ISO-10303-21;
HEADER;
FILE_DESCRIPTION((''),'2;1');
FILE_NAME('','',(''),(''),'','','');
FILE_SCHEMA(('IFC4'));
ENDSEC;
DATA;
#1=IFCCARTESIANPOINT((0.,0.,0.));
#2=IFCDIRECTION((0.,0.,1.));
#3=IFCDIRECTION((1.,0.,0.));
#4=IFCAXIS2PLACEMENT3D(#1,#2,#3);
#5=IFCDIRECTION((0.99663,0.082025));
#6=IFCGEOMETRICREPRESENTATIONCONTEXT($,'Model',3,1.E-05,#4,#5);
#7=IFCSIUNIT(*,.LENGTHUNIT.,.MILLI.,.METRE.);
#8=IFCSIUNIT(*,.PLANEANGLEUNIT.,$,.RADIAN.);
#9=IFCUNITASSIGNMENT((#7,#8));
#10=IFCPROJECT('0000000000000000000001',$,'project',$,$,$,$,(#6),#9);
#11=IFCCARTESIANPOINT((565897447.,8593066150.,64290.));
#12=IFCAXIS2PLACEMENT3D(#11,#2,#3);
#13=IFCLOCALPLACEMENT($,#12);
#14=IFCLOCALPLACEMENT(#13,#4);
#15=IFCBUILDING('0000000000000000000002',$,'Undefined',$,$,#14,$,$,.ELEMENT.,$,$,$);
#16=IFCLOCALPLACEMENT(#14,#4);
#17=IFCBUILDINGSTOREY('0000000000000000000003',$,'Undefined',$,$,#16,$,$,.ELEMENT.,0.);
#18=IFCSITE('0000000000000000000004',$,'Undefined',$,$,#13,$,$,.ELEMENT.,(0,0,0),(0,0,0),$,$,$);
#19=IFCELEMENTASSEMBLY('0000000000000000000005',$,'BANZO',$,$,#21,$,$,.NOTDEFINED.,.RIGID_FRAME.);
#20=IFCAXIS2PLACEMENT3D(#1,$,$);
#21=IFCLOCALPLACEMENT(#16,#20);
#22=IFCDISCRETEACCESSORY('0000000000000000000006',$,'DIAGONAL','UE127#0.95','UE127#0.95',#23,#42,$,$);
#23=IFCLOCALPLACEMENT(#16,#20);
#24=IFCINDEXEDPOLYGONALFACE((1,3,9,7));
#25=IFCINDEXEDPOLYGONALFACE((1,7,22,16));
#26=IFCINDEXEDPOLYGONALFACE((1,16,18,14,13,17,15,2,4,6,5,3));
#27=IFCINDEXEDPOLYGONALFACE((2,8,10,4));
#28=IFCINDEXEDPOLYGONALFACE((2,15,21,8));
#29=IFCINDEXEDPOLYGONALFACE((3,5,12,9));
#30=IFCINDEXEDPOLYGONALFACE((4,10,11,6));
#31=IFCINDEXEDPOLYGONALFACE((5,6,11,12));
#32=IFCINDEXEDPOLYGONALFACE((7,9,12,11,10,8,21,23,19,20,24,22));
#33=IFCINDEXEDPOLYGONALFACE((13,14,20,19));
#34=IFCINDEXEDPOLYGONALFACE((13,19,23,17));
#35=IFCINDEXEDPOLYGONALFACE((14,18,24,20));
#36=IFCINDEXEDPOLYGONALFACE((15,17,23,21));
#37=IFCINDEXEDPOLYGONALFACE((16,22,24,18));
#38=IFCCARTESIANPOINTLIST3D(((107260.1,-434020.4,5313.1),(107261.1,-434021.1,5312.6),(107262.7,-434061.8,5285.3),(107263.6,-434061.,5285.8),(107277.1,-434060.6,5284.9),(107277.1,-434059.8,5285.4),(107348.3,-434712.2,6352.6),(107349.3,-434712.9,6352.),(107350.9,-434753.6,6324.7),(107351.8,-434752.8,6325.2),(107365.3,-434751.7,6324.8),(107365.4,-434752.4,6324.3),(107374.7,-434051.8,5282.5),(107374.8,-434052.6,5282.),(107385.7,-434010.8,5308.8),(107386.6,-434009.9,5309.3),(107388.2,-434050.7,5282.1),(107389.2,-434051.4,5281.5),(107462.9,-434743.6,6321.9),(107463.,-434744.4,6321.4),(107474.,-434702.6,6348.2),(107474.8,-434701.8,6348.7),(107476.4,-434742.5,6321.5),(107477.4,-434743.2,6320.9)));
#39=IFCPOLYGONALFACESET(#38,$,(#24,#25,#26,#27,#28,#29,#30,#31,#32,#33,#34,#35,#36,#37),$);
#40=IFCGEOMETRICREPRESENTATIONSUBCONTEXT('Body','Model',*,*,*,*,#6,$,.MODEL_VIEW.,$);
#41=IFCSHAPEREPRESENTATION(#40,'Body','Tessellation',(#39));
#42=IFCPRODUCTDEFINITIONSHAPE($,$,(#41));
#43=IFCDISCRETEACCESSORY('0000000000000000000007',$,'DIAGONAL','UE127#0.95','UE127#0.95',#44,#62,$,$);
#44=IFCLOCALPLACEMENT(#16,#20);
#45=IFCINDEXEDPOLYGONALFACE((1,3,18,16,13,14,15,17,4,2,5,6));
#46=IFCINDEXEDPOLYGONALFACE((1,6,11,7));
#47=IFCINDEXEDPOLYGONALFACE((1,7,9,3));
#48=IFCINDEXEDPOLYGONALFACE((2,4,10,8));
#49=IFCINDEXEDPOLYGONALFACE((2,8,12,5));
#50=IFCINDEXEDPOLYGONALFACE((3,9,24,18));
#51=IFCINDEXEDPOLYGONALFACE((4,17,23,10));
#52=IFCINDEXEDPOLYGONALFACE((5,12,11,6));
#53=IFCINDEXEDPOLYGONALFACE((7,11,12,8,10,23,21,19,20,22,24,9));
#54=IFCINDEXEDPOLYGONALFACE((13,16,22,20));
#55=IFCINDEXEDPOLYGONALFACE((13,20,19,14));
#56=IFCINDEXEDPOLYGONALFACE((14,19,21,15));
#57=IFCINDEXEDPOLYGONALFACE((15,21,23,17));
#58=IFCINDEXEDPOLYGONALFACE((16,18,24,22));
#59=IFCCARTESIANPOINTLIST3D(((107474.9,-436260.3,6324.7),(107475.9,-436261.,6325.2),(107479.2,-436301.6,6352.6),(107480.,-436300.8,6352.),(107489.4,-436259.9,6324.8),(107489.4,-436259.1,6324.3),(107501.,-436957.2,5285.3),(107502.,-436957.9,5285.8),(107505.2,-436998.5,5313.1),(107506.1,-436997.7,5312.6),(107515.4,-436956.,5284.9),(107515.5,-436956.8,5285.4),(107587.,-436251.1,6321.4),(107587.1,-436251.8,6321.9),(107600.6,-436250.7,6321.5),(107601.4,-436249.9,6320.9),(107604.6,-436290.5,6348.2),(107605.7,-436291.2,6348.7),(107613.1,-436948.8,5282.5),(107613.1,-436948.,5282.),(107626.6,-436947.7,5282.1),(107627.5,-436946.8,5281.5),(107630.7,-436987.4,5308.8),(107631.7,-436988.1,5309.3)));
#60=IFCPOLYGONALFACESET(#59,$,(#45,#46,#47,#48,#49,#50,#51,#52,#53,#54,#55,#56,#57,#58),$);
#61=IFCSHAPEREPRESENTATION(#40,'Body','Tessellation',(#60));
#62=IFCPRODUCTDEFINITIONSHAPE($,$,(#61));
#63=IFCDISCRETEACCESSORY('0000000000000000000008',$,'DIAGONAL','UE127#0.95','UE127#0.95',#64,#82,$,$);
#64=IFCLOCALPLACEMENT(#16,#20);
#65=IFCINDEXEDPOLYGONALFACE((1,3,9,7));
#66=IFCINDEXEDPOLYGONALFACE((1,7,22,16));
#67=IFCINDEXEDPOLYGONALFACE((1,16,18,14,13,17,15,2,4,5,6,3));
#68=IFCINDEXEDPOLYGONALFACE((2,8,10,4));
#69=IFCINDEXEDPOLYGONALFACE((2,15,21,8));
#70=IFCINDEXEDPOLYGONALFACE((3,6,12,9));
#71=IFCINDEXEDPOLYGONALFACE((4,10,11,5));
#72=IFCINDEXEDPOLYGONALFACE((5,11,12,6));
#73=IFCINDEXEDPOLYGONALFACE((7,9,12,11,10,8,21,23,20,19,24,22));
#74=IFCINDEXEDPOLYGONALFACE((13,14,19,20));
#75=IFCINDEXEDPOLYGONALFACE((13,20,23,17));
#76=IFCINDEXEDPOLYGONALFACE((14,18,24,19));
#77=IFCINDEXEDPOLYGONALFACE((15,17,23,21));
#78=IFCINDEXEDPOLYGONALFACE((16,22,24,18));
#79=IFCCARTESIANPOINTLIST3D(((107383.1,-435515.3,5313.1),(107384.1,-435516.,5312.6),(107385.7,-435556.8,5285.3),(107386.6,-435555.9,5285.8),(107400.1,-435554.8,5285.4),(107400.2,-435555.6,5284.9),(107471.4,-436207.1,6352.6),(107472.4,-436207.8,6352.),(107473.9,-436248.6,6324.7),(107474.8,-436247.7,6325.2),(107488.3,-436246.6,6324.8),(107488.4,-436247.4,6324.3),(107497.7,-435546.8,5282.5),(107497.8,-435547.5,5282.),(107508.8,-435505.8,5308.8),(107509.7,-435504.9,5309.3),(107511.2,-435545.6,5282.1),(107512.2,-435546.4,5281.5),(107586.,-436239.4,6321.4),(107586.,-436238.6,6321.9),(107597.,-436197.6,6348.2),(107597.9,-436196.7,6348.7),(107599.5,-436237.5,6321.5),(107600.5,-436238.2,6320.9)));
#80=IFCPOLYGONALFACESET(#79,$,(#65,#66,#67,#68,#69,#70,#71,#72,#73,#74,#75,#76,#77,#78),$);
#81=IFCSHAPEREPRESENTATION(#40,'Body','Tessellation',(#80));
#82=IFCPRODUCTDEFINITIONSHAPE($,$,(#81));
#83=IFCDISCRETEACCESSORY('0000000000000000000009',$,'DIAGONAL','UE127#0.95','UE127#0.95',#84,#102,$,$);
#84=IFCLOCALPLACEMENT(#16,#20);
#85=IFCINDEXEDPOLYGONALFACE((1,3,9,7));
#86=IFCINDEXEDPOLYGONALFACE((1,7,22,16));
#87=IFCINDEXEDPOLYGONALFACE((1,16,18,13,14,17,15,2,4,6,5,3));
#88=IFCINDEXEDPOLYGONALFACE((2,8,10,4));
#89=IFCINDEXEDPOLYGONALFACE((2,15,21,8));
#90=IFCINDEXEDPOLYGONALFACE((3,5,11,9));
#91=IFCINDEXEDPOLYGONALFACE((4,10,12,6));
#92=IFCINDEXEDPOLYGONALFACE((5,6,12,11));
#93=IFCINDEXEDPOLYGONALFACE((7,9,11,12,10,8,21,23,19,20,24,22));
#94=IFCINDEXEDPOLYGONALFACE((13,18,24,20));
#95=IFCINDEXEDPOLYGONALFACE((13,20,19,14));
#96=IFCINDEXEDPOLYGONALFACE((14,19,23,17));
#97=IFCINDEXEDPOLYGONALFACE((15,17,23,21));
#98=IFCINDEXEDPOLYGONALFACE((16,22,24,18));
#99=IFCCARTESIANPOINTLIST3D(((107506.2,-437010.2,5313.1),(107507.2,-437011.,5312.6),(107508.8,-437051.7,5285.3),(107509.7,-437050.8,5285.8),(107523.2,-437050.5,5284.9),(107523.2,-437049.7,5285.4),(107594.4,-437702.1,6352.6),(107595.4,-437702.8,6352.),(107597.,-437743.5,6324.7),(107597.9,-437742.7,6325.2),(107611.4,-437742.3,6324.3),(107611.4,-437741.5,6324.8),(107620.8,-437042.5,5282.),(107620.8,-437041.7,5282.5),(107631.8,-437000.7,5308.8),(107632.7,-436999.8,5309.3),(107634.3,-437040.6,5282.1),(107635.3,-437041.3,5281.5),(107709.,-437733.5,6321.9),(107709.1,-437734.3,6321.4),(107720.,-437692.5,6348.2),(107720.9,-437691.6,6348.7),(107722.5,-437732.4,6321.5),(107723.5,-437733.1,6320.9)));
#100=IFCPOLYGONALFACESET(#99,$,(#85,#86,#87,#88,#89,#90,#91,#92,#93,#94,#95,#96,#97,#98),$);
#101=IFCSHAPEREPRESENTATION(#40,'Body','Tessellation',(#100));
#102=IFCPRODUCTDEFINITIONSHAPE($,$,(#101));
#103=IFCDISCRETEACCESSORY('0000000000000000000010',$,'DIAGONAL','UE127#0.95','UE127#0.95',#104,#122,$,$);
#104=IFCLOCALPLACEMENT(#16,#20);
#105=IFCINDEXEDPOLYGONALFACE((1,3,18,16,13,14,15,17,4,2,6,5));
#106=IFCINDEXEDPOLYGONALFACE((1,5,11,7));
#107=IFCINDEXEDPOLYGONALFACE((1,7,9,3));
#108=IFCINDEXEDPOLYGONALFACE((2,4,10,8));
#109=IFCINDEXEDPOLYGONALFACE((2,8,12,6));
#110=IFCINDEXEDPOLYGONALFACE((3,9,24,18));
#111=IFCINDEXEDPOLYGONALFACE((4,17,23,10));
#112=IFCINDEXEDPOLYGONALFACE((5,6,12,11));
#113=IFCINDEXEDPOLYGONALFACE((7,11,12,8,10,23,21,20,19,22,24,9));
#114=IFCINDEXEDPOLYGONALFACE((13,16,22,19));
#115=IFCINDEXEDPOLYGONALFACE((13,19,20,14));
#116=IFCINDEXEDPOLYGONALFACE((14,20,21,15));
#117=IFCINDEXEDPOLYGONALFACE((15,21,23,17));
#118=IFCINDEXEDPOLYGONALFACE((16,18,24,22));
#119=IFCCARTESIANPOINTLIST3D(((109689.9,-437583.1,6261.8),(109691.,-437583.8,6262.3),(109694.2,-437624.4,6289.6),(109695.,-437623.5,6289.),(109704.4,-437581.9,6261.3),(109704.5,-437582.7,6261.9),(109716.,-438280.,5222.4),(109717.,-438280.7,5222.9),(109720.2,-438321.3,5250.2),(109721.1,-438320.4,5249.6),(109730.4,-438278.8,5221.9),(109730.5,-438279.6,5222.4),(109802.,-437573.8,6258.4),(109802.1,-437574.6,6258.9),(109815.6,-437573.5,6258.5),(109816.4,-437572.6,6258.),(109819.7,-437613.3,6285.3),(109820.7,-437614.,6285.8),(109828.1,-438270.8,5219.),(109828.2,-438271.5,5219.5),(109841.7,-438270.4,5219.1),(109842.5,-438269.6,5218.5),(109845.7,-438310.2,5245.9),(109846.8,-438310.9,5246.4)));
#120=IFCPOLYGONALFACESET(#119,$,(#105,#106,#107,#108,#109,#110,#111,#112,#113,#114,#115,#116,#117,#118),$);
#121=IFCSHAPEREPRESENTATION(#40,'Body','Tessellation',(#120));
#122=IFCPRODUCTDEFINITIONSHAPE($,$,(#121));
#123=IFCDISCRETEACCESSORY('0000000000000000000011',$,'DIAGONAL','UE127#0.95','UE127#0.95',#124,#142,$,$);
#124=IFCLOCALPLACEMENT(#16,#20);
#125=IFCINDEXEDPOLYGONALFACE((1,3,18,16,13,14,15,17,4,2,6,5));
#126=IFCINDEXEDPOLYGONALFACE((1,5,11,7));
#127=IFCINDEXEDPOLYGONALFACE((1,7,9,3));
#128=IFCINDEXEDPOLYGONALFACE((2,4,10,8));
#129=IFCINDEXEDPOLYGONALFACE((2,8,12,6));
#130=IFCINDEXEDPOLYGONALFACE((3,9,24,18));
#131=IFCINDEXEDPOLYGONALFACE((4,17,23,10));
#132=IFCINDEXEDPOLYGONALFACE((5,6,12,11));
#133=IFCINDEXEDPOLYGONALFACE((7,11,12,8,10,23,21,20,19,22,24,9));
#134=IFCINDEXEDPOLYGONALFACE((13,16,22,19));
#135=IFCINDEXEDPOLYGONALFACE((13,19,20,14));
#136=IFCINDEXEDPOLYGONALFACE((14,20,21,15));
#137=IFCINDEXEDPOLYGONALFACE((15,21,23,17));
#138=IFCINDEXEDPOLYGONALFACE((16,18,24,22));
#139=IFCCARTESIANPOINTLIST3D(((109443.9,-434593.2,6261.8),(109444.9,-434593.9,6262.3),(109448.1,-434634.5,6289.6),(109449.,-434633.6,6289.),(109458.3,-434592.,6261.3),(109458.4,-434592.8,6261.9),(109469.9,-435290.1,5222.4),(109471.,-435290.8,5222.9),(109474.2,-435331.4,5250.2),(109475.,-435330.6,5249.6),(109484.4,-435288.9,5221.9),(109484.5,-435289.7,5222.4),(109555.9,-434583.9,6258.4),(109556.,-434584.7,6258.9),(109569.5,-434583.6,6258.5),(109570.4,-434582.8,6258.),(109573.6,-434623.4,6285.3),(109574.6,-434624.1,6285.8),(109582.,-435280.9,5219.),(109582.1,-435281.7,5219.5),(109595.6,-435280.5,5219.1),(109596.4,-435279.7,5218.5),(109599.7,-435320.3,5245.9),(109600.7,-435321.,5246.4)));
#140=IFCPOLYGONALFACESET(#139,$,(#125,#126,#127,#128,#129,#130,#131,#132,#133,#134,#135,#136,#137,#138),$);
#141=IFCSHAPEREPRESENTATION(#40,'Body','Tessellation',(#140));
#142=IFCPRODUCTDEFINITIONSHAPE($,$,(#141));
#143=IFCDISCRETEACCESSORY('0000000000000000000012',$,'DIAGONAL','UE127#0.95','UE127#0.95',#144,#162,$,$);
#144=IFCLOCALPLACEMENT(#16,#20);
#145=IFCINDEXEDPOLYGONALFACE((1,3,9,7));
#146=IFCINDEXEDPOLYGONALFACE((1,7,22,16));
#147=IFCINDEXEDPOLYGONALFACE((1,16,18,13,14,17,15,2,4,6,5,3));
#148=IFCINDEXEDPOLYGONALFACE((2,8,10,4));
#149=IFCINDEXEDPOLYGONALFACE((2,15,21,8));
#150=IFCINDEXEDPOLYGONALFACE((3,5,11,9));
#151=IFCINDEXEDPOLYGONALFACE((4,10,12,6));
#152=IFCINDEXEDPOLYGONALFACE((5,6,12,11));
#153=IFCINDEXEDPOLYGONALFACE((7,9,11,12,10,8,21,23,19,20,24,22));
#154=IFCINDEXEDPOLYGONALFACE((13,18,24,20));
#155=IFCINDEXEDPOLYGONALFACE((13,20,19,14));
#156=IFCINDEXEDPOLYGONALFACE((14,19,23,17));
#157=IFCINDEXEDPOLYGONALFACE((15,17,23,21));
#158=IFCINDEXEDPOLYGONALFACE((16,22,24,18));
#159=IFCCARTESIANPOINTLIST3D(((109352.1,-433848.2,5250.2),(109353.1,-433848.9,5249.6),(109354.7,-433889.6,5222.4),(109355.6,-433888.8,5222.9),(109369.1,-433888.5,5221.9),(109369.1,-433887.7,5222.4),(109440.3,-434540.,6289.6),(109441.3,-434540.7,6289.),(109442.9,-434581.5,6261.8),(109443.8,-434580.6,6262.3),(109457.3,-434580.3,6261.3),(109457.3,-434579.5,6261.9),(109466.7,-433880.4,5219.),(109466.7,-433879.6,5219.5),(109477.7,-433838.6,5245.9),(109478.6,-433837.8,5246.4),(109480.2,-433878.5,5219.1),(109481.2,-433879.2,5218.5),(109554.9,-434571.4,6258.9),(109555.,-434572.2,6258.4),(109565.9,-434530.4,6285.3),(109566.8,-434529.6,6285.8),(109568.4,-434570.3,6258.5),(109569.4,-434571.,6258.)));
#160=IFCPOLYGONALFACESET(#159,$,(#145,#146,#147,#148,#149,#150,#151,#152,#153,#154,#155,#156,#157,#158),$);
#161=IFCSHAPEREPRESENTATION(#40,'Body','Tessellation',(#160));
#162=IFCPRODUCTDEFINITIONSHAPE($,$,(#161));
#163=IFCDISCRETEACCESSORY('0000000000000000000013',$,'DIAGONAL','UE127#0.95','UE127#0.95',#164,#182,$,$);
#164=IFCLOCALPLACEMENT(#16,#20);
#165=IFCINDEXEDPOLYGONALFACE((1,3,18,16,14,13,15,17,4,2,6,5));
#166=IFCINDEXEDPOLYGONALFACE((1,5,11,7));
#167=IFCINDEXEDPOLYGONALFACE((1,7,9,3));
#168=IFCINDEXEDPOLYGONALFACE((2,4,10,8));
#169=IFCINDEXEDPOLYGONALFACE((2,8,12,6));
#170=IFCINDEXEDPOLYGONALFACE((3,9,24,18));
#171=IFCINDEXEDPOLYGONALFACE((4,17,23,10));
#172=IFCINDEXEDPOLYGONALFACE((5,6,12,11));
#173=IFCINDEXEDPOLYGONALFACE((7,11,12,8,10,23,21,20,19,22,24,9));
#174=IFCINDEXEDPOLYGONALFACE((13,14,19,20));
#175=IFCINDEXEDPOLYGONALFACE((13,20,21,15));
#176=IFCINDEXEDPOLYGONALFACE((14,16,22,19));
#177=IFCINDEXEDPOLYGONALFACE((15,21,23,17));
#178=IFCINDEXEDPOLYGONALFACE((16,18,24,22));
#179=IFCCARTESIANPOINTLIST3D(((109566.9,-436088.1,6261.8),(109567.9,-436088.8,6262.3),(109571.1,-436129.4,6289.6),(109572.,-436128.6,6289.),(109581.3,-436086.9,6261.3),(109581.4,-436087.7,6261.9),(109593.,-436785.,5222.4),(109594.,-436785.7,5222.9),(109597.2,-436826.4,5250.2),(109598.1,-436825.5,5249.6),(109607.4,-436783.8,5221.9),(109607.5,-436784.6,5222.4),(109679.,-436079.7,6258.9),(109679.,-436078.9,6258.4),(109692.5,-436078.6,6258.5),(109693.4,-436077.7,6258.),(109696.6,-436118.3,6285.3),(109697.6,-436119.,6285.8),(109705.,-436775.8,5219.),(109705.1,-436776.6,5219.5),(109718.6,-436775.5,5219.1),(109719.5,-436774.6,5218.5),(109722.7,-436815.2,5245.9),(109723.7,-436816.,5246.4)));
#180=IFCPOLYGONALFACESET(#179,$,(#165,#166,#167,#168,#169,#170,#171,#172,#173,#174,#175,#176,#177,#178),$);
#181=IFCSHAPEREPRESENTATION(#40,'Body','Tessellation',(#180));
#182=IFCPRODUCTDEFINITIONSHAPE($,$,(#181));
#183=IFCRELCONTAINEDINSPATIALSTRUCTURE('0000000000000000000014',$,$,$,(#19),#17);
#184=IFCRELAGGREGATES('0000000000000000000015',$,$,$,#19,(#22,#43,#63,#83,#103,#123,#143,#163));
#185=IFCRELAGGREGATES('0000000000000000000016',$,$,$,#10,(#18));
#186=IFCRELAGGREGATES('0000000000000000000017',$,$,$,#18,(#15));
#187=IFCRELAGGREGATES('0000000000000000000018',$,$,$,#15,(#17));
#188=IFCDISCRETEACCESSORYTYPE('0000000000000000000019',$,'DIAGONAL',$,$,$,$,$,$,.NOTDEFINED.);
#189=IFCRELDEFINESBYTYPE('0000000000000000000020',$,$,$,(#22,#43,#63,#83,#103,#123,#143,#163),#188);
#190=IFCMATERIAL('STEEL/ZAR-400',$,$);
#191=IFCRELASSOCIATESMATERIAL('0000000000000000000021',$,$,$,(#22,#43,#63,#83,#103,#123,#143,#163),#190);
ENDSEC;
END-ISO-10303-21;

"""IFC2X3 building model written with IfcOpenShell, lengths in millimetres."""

from ifc_helpers import new_model, si_unit, direction, frame, frame_2d, origin_with_axes, place, context, subcontext, project, spatial, c_section, extrude, material, type_object, element, aggregate, save


model = new_model("IFC2X3")

# Units and contexts
model_context = context("Model", 3, precision=1e-05, world=origin_with_axes(), true_north=direction((0.99663, 0.082025)))
body_context = subcontext(model_context, "Body", "Model", "MODEL_VIEW")
ifc_project = project(units=[si_unit("LENGTHUNIT", "METRE", prefix="MILLI"), si_unit("PLANEANGLEUNIT", "RADIAN")], contexts=[model_context])

# Site, building, storey
site_placement = place(None, frame((565897447.0, 8593066150.0, 64290.0), z_axis=(0.0, 0.0, 1.0), x_axis=(1.0, 0.0, 0.0)))
site = spatial("IfcSite", under=ifc_project, at=site_placement, Name="Undefined", CompositionType="ELEMENT", RefLatitude=(0, 0, 0), RefLongitude=(0, 0, 0))
building_placement = place(site_placement, origin_with_axes())
building = spatial("IfcBuilding", under=site, at=building_placement, Name="Undefined", CompositionType="ELEMENT")
storey_placement = place(building_placement, origin_with_axes())
storey = spatial("IfcBuildingStorey", under=building, at=storey_placement, Name="Undefined", CompositionType="ELEMENT", Elevation=0.0)

# Element assembly, discrete accessories
assembly_placement = place(storey_placement, origin_with_axes())
assembly = element("IfcElementAssembly", 1, at=assembly_placement, inside=storey, Name="BANZO", AssemblyPlace="NOTDEFINED", PredefinedType="RIGID_FRAME")
ifc_material_1 = material(Name="STEEL/ZAR-400")
discrete_accessory_type_1 = type_object("IfcDiscreteAccessoryType", Name="DIAGONAL")
discrete_accessory_1_placement = place(assembly_placement, frame((107412.9, -434727.7, 6336.7), z_axis=(0.996182, 0.081989, -0.029987), x_axis=(-0.070485, 0.552697, -0.830396)))
discrete_accessory_1 = element("IfcDiscreteAccessory", 2, at=discrete_accessory_1_placement, type_object=discrete_accessory_type_1, material=ifc_material_1, Name="DIAGONAL", Description="UE127#0.95", ObjectType="UE127#0.95", context=body_context, shape_type="SweptSolid", body=[
    extrude(c_section(Depth=127.0, Width=50.0, WallThickness=0.9, Girth=14.5, at=frame_2d((0.0, 0.0), x_axis=(1.0, 0.0))), frame((1251.7, 0.0, 0.0), z_axis=(-1.0, 0.0, 0.0), x_axis=(0.0, -1.0, 0.0)), (0.0, 0.0, 1.0), 1251.7),
])
discrete_accessory_2_placement = place(assembly_placement, frame((107566.4, -436972.7, 5297.3), z_axis=(0.996182, 0.081989, -0.029987), x_axis=(-0.020829, 0.556784, 0.830396)))
discrete_accessory_2 = element("IfcDiscreteAccessory", 3, at=discrete_accessory_2_placement, type_object=discrete_accessory_type_1, material=ifc_material_1, Name="DIAGONAL", Description="UE127#0.95", ObjectType="UE127#0.95", context=body_context, shape_type="SweptSolid", body=[
    extrude(c_section(Depth=127.0, Width=50.0, WallThickness=0.9, Girth=14.5, at=frame_2d((0.0, 0.0), x_axis=(1.0, 0.0))), frame((1251.7, 0.0, 0.0), z_axis=(-1.0, 0.0, 0.0), x_axis=(0.0, -1.0, 0.0)), (0.0, 0.0, 1.0), 1251.7),
])
discrete_accessory_3_placement = place(assembly_placement, frame((107535.9, -436222.6, 6336.7), z_axis=(0.996182, 0.081989, -0.029987), x_axis=(-0.070485, 0.552697, -0.830396)))
discrete_accessory_3 = element("IfcDiscreteAccessory", 4, at=discrete_accessory_3_placement, type_object=discrete_accessory_type_1, material=ifc_material_1, Name="DIAGONAL", Description="UE127#0.95", ObjectType="UE127#0.95", context=body_context, shape_type="SweptSolid", body=[
    extrude(c_section(Depth=127.0, Width=50.0, WallThickness=0.9, Girth=14.5, at=frame_2d((0.0, 0.0), x_axis=(1.0, 0.0))), frame((1251.7, 0.0, 0.0), z_axis=(-1.0, 0.0, 0.0), x_axis=(0.0, -1.0, 0.0)), (0.0, 0.0, 1.0), 1251.7),
])
discrete_accessory_4_placement = place(assembly_placement, frame((107659.0, -437717.6, 6336.7), z_axis=(0.996182, 0.081989, -0.029987), x_axis=(-0.070485, 0.552697, -0.830396)))
discrete_accessory_4 = element("IfcDiscreteAccessory", 5, at=discrete_accessory_4_placement, type_object=discrete_accessory_type_1, material=ifc_material_1, Name="DIAGONAL", Description="UE127#0.95", ObjectType="UE127#0.95", context=body_context, shape_type="SweptSolid", body=[
    extrude(c_section(Depth=127.0, Width=50.0, WallThickness=0.9, Girth=14.5, at=frame_2d((0.0, 0.0), x_axis=(1.0, 0.0))), frame((1251.7, 0.0, 0.0), z_axis=(-1.0, 0.0, 0.0), x_axis=(0.0, -1.0, 0.0)), (0.0, 0.0, 1.0), 1251.7),
])
discrete_accessory_5_placement = place(assembly_placement, frame((109781.4, -438295.4, 5234.4), z_axis=(0.996182, 0.081989, -0.029987), x_axis=(-0.020829, 0.556784, 0.830396)))
discrete_accessory_5 = element("IfcDiscreteAccessory", 6, at=discrete_accessory_5_placement, type_object=discrete_accessory_type_1, material=ifc_material_1, Name="DIAGONAL", Description="UE127#0.95", ObjectType="UE127#0.95", context=body_context, shape_type="SweptSolid", body=[
    extrude(c_section(Depth=127.0, Width=50.0, WallThickness=0.9, Girth=14.5, at=frame_2d((0.0, 0.0), x_axis=(1.0, 0.0))), frame((1251.7, 0.0, 0.0), z_axis=(-1.0, 0.0, 0.0), x_axis=(0.0, -1.0, 0.0)), (0.0, 0.0, 1.0), 1251.7),
])
discrete_accessory_6_placement = place(assembly_placement, frame((109535.3, -435305.6, 5234.4), z_axis=(0.996182, 0.081989, -0.029987), x_axis=(-0.020829, 0.556784, 0.830396)))
discrete_accessory_6 = element("IfcDiscreteAccessory", 7, at=discrete_accessory_6_placement, type_object=discrete_accessory_type_1, material=ifc_material_1, Name="DIAGONAL", Description="UE127#0.95", ObjectType="UE127#0.95", context=body_context, shape_type="SweptSolid", body=[
    extrude(c_section(Depth=127.0, Width=50.0, WallThickness=0.9, Girth=14.5, at=frame_2d((0.0, 0.0), x_axis=(1.0, 0.0))), frame((1251.7, 0.0, 0.0), z_axis=(-1.0, 0.0, 0.0), x_axis=(0.0, -1.0, 0.0)), (0.0, 0.0, 1.0), 1251.7),
])
discrete_accessory_7_placement = place(assembly_placement, frame((109504.9, -434555.5, 6273.8), z_axis=(0.996182, 0.081989, -0.029987), x_axis=(-0.070485, 0.552697, -0.830396)))
discrete_accessory_7 = element("IfcDiscreteAccessory", 8, at=discrete_accessory_7_placement, type_object=discrete_accessory_type_1, material=ifc_material_1, Name="DIAGONAL", Description="UE127#0.95", ObjectType="UE127#0.95", context=body_context, shape_type="SweptSolid", body=[
    extrude(c_section(Depth=127.0, Width=50.0, WallThickness=0.9, Girth=14.5, at=frame_2d((0.0, 0.0), x_axis=(1.0, 0.0))), frame((1251.7, 0.0, 0.0), z_axis=(-1.0, 0.0, 0.0), x_axis=(0.0, -1.0, 0.0)), (0.0, 0.0, 1.0), 1251.7),
])
discrete_accessory_8_placement = place(assembly_placement, frame((109658.3, -436800.5, 5234.4), z_axis=(0.996182, 0.081989, -0.029987), x_axis=(-0.020829, 0.556784, 0.830396)))
discrete_accessory_8 = element("IfcDiscreteAccessory", 9, at=discrete_accessory_8_placement, type_object=discrete_accessory_type_1, material=ifc_material_1, Name="DIAGONAL", Description="UE127#0.95", ObjectType="UE127#0.95", context=body_context, shape_type="SweptSolid", body=[
    extrude(c_section(Depth=127.0, Width=50.0, WallThickness=0.9, Girth=14.5, at=frame_2d((0.0, 0.0), x_axis=(1.0, 0.0))), frame((1251.7, 0.0, 0.0), z_axis=(-1.0, 0.0, 0.0), x_axis=(0.0, -1.0, 0.0)), (0.0, 0.0, 1.0), 1251.7),
])
aggregate(assembly, [discrete_accessory_1, discrete_accessory_2, discrete_accessory_3, discrete_accessory_4, discrete_accessory_5, discrete_accessory_6, discrete_accessory_7, discrete_accessory_8])

save(model, "model.ifc")
